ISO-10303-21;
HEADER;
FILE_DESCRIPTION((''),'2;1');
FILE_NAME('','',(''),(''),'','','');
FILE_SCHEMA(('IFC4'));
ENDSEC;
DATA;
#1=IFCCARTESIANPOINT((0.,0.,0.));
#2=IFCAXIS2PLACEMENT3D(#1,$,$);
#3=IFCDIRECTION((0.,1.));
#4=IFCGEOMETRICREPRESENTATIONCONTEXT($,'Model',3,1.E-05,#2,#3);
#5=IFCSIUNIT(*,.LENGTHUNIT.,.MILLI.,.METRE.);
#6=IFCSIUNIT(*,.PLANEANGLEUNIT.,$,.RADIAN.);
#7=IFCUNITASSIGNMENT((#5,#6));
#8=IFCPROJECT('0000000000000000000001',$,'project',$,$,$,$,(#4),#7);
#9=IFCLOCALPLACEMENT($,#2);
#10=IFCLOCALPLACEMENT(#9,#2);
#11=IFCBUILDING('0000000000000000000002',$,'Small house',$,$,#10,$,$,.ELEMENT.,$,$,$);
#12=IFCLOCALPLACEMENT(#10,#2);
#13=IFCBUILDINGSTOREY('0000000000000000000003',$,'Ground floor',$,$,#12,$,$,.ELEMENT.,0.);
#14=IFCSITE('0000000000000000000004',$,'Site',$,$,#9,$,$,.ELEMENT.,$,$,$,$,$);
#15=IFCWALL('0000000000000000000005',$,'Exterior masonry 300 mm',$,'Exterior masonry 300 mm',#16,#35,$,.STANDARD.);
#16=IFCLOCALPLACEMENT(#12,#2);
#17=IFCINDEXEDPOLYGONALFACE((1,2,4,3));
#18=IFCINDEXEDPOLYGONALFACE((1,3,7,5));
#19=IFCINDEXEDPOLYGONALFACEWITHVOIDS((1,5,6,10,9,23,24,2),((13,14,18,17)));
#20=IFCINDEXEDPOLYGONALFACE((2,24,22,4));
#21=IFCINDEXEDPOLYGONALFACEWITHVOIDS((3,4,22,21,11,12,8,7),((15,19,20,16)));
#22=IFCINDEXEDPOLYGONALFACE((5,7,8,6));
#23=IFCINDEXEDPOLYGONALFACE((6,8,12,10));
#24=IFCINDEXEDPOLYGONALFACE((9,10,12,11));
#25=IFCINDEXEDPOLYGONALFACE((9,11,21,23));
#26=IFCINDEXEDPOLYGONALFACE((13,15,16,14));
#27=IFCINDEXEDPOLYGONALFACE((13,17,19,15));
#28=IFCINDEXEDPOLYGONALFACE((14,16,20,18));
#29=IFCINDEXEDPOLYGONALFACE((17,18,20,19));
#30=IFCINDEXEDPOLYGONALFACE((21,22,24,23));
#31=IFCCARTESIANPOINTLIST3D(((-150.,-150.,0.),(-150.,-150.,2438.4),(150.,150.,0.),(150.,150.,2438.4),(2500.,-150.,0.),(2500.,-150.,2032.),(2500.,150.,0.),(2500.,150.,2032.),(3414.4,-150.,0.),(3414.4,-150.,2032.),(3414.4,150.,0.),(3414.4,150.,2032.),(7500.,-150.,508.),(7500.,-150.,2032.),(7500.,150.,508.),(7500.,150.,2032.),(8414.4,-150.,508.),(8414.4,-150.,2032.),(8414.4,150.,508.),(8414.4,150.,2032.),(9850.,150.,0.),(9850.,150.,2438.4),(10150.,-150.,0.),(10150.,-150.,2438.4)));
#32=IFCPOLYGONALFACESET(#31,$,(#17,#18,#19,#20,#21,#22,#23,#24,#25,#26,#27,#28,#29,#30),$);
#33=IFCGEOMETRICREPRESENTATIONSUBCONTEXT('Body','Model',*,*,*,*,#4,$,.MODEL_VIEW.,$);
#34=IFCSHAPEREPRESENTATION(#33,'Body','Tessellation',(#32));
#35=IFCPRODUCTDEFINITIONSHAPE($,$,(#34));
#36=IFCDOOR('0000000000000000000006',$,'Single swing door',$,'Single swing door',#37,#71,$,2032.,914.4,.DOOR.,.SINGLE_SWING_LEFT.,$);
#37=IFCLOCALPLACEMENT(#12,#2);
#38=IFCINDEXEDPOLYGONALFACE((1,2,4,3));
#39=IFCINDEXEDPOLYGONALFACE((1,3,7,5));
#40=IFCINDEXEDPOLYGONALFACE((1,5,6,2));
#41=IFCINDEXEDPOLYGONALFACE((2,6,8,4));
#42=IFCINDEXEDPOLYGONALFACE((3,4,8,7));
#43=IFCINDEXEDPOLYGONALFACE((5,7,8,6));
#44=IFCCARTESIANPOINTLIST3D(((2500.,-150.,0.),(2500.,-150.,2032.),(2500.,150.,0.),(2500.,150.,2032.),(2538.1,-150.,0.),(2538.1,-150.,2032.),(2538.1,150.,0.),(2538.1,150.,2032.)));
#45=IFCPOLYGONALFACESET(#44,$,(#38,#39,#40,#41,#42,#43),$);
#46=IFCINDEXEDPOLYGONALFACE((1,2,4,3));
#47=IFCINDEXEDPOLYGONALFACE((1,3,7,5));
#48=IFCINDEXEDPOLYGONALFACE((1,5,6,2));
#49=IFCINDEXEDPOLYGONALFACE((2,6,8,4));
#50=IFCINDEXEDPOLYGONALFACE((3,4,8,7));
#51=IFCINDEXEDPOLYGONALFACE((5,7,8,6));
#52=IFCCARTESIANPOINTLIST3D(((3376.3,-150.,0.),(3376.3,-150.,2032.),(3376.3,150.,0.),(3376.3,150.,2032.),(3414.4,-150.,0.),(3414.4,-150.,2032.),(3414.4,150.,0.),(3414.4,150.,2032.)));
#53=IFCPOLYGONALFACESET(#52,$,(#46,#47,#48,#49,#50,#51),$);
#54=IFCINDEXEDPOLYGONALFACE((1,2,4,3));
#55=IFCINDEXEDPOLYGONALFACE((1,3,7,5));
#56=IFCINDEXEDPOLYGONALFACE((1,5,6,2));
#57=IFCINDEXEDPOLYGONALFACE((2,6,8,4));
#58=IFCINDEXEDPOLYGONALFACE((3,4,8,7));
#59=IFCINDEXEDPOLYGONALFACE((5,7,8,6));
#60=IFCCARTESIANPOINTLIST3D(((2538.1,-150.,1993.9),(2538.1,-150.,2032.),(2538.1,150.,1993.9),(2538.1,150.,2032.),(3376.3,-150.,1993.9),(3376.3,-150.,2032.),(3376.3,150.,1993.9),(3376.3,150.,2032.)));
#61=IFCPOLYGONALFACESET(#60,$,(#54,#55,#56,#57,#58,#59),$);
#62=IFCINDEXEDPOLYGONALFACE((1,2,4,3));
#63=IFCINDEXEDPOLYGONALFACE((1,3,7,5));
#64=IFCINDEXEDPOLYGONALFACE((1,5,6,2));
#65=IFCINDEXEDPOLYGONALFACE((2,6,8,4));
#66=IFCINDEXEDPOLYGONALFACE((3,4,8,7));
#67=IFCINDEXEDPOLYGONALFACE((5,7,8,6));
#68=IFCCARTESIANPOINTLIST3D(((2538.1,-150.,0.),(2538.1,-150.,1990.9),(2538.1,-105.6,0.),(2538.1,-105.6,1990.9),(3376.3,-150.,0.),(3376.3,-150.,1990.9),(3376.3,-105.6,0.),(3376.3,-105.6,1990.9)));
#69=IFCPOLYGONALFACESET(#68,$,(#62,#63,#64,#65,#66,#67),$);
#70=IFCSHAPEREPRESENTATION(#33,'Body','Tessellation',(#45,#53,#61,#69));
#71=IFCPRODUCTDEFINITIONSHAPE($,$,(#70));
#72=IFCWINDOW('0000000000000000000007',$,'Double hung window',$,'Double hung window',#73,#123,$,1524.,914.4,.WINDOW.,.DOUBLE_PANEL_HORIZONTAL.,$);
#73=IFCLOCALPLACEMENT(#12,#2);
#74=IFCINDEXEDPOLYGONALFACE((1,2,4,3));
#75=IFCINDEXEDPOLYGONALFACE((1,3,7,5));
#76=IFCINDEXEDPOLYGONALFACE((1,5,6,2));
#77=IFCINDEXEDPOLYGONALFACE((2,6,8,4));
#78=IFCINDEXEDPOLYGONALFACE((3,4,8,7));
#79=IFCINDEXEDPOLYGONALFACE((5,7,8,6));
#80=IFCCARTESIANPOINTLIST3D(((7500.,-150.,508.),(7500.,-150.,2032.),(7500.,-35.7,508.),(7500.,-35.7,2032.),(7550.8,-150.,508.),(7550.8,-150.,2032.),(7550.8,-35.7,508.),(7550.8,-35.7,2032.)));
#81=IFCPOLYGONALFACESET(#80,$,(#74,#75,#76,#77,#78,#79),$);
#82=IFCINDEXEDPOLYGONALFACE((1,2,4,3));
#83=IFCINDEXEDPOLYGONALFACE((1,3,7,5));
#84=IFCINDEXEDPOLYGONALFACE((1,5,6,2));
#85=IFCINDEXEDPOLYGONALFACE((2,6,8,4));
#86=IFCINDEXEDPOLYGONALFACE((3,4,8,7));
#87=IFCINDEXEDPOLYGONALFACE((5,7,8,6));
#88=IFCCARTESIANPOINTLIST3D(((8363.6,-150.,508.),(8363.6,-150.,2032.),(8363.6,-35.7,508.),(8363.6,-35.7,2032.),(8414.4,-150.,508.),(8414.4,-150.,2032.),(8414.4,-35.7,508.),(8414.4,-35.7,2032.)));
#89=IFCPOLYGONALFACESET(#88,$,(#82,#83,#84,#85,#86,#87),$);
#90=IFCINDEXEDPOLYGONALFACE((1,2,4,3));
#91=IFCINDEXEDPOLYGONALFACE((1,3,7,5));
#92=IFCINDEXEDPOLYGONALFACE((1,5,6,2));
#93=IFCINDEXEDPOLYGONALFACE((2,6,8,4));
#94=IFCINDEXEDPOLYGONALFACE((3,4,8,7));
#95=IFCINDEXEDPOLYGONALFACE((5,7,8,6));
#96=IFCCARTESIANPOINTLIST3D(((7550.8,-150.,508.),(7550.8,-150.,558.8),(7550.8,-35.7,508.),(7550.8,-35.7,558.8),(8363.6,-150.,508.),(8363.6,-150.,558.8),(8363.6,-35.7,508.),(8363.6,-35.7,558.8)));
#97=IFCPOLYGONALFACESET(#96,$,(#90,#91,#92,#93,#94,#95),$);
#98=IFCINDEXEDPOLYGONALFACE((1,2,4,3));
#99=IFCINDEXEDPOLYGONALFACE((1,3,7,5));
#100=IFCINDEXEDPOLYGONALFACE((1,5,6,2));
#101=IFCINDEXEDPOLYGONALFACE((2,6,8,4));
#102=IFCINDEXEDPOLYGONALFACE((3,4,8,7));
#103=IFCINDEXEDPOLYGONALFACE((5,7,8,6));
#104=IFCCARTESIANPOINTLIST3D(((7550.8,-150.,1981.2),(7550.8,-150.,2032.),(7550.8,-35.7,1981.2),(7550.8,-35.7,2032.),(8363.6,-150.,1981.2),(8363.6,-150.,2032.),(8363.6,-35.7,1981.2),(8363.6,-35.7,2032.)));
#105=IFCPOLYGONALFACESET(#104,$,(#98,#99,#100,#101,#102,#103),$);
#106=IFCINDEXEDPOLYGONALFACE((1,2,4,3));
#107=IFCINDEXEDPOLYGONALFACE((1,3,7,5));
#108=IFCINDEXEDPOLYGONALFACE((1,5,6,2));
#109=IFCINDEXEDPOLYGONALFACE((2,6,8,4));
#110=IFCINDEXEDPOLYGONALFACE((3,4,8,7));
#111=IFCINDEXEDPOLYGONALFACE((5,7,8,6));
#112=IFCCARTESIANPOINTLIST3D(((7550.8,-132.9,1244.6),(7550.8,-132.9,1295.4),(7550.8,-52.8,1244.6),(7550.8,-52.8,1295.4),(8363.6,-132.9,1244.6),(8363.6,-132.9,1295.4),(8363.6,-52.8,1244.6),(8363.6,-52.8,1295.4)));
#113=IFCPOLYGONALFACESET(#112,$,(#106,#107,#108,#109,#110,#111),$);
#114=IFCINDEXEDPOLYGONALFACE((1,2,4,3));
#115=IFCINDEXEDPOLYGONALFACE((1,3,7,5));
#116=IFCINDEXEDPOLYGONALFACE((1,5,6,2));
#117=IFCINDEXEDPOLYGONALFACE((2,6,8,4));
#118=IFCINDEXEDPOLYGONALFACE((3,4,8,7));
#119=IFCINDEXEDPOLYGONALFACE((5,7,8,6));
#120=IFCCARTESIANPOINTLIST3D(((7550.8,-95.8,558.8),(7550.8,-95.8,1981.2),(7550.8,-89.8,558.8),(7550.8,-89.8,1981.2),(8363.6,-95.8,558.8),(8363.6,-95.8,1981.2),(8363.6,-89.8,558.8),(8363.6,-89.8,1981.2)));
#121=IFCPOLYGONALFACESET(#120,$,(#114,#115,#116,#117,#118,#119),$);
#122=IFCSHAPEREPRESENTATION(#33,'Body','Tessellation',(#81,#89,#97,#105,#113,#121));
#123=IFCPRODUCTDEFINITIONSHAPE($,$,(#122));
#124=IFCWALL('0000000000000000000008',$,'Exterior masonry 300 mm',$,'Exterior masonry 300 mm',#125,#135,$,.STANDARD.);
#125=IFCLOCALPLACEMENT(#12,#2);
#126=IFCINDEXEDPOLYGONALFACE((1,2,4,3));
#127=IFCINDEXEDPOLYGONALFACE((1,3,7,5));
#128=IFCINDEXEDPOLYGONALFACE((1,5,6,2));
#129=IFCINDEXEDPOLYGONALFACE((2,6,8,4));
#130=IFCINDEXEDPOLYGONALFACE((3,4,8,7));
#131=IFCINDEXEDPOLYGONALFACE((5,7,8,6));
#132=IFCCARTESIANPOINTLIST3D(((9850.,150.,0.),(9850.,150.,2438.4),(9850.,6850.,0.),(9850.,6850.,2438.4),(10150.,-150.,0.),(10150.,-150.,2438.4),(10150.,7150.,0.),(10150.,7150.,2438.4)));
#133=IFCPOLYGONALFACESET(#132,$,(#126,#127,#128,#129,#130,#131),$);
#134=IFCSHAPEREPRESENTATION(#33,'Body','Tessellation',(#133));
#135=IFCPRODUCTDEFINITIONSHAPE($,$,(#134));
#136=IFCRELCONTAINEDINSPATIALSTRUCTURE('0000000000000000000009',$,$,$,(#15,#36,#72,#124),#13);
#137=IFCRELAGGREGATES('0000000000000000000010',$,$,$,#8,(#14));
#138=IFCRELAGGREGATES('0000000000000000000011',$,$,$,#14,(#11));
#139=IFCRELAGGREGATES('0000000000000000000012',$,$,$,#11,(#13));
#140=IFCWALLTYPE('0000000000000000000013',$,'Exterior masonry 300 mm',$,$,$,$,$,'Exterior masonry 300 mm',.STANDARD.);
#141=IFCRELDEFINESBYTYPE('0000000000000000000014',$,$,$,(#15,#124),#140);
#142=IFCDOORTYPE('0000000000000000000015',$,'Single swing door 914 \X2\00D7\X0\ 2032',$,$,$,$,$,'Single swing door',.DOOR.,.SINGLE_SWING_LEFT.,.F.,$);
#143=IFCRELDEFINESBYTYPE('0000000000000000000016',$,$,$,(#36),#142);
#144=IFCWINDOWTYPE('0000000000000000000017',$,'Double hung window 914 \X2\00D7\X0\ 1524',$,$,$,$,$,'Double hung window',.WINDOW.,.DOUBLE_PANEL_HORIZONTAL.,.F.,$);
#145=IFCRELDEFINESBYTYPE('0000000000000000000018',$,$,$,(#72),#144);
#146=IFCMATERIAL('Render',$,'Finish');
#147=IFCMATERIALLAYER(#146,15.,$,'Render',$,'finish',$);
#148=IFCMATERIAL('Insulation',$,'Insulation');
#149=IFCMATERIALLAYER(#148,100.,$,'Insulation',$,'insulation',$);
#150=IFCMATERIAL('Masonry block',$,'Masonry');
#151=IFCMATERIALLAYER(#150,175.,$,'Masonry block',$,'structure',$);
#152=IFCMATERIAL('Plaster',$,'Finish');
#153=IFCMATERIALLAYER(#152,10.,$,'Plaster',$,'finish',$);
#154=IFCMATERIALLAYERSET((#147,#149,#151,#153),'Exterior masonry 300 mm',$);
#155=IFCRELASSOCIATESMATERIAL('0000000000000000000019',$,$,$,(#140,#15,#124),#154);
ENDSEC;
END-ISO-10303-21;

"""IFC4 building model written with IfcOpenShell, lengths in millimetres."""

from ifc_helpers import new_model, si_unit, direction, frame, origin, origin_with_axes, place, context, subcontext, project, spatial, polyline, outline, extrude, material, layer, layer_set, layer_usage, type_object, element, fill, save


model = new_model("IFC4")

# Units and contexts
model_context = context("Model", 3, precision=1e-05, world=origin(), true_north=direction((0.0, 1.0)))
body_context = subcontext(model_context, "Body", "Model", "MODEL_VIEW")
ifc_project = project(units=[si_unit("LENGTHUNIT", "METRE", prefix="MILLI"), si_unit("PLANEANGLEUNIT", "RADIAN")], contexts=[model_context])

# Site, building, storey
site_placement = place(None, origin())
site = spatial("IfcSite", under=ifc_project, at=site_placement, Name="Site", CompositionType="ELEMENT")
building_placement = place(site_placement, origin())
building = spatial("IfcBuilding", under=site, at=building_placement, Name="Small house", CompositionType="ELEMENT")
storey_placement = place(building_placement, origin())
storey = spatial("IfcBuildingStorey", under=building, at=storey_placement, Name="Ground floor", CompositionType="ELEMENT", Elevation=0.0)

# Wall, openings, door, window
ifc_material_1 = material(Name="Render", Category="Finish")
ifc_layer_1 = layer(ifc_material_1, 15.0, Name="Render", Category="finish")
ifc_material_2 = material(Name="Insulation", Category="Insulation")
ifc_layer_2 = layer(ifc_material_2, 100.0, Name="Insulation", Category="insulation")
ifc_material_3 = material(Name="Masonry block", Category="Masonry")
ifc_layer_3 = layer(ifc_material_3, 175.0, Name="Masonry block", Category="structure")
ifc_material_4 = material(Name="Plaster", Category="Finish")
ifc_layer_4 = layer(ifc_material_4, 10.0, Name="Plaster", Category="finish")
ifc_layer_set_1 = layer_set([ifc_layer_1, ifc_layer_2, ifc_layer_3, ifc_layer_4], Name="Exterior masonry 300 mm")
ifc_layer_usage_1 = layer_usage(ifc_layer_set_1, "AXIS2", "POSITIVE", -150.0)
wall_type_1 = type_object("IfcWallType", Name="Exterior masonry 300 mm", ElementType="Exterior masonry 300 mm", PredefinedType="STANDARD", material=ifc_layer_set_1)
wall_1_placement = place(storey_placement, origin_with_axes())
wall_1 = element("IfcWall", 1, at=wall_1_placement, inside=storey, type_object=wall_type_1, material=ifc_layer_usage_1, Name="Exterior masonry 300 mm", ObjectType="Exterior masonry 300 mm", PredefinedType="STANDARD", context=body_context, shape_type="SweptSolid", body=[
    extrude(outline(polyline([(-150.0, -150.0), (10150.0, -150.0), (9850.0, 150.0), (150.0, 150.0), (-150.0, -150.0)])), origin(), (0.0, 0.0, 1.0), 2438.4),
])
opening_1_placement = place(wall_1_placement, frame((2500.0, 0.0, 0.0), z_axis=(0.0, 0.0, 1.0), x_axis=(1.0, 0.0, 0.0)))
opening_1 = element("IfcOpeningElement", 2, at=opening_1_placement, cuts=wall_1, PredefinedType="OPENING", context=body_context, shape_type="SweptSolid", body=[
    extrude(outline(polyline([(0.0, -160.0), (914.4, -160.0), (914.4, 160.0), (0.0, 160.0), (0.0, -160.0)])), origin(), (0.0, 0.0, 1.0), 2032.0),
])
opening_2_placement = place(wall_1_placement, frame((7500.0, 0.0, 508.0), z_axis=(0.0, 0.0, 1.0), x_axis=(1.0, 0.0, 0.0)))
opening_2 = element("IfcOpeningElement", 3, at=opening_2_placement, cuts=wall_1, PredefinedType="OPENING", context=body_context, shape_type="SweptSolid", body=[
    extrude(outline(polyline([(0.0, -160.0), (914.4, -160.0), (914.4, 160.0), (0.0, 160.0), (0.0, -160.0)])), origin(), (0.0, 0.0, 1.0), 1524.0),
])
door_type = type_object("IfcDoorType", Name="Single swing door 914 × 2032", ElementType="Single swing door", OperationType="SINGLE_SWING_LEFT", ParameterTakesPrecedence=False, PredefinedType="DOOR")
door_1_placement = place(opening_1_placement, origin_with_axes())
door_1 = element("IfcDoor", 4, at=door_1_placement, inside=storey, type_object=door_type, Name="Single swing door", ObjectType="Single swing door", OperationType="SINGLE_SWING_LEFT", OverallHeight=2032.0, OverallWidth=914.4, PredefinedType="DOOR", context=body_context, shape_type="SweptSolid", body=[
    extrude(outline(polyline([(0.0, -150.0), (38.1, -150.0), (38.1, 150.0), (0.0, 150.0), (0.0, -150.0)])), origin(), (0.0, 0.0, 1.0), 2032.0),
    extrude(outline(polyline([(876.3, -150.0), (914.4, -150.0), (914.4, 150.0), (876.3, 150.0), (876.3, -150.0)])), origin(), (0.0, 0.0, 1.0), 2032.0),
    extrude(outline(polyline([(38.1, -150.0), (876.3, -150.0), (876.3, 150.0), (38.1, 150.0), (38.1, -150.0)])), frame((0.0, 0.0, 1993.9)), (0.0, 0.0, 1.0), 38.1),
    extrude(outline(polyline([(38.1, -150.0), (876.3, -150.0), (876.3, -105.5), (38.1, -105.5), (38.1, -150.0)])), origin(), (0.0, 0.0, 1.0), 1990.9),
])
fill(opening_1, door_1)
window_type = type_object("IfcWindowType", Name="Double hung window 914 × 1524", ElementType="Double hung window", ParameterTakesPrecedence=False, PartitioningType="DOUBLE_PANEL_HORIZONTAL", PredefinedType="WINDOW")
window_1_placement = place(opening_2_placement, origin_with_axes())
window_1 = element("IfcWindow", 5, at=window_1_placement, inside=storey, type_object=window_type, Name="Double hung window", ObjectType="Double hung window", OverallHeight=1524.0, OverallWidth=914.4, PartitioningType="DOUBLE_PANEL_HORIZONTAL", PredefinedType="WINDOW", context=body_context, shape_type="SweptSolid", body=[
    extrude(outline(polyline([(0.0, -150.0), (50.8, -150.0), (50.8, -35.7), (0.0, -35.7), (0.0, -150.0)])), origin(), (0.0, 0.0, 1.0), 1524.0),
    extrude(outline(polyline([(863.6, -150.0), (914.4, -150.0), (914.4, -35.7), (863.6, -35.7), (863.6, -150.0)])), origin(), (0.0, 0.0, 1.0), 1524.0),
    extrude(outline(polyline([(50.8, -150.0), (863.6, -150.0), (863.6, -35.7), (50.8, -35.7), (50.8, -150.0)])), origin(), (0.0, 0.0, 1.0), 50.8),
    extrude(outline(polyline([(50.8, -150.0), (863.6, -150.0), (863.6, -35.7), (50.8, -35.7), (50.8, -150.0)])), frame((0.0, 0.0, 1473.2)), (0.0, 0.0, 1.0), 50.8),
    extrude(outline(polyline([(50.8, -132.9), (863.6, -132.9), (863.6, -52.8), (50.8, -52.8), (50.8, -132.9)])), frame((0.0, 0.0, 736.6)), (0.0, 0.0, 1.0), 50.8),
    extrude(outline(polyline([(50.8, -95.8), (863.6, -95.8), (863.6, -89.8), (50.8, -89.8), (50.8, -95.8)])), frame((0.0, 0.0, 50.8)), (0.0, 0.0, 1.0), 1422.4),
])
fill(opening_2, window_1)

# Wall
ifc_layer_usage_2 = layer_usage(ifc_layer_set_1, "AXIS2", "POSITIVE", -150.0)
wall_2_placement = place(storey_placement, frame((10000.0, 0.0, 0.0), z_axis=(0.0, 0.0, 1.0), x_axis=(0.0, 1.0, 0.0)))
element("IfcWall", 6, at=wall_2_placement, inside=storey, type_object=wall_type_1, material=ifc_layer_usage_2, Name="Exterior masonry 300 mm", ObjectType="Exterior masonry 300 mm", PredefinedType="STANDARD", context=body_context, shape_type="SweptSolid", body=[
    extrude(outline(polyline([(-150.0, -150.0), (7150.0, -150.0), (6850.0, 150.0), (150.0, 150.0), (-150.0, -150.0)])), origin(), (0.0, 0.0, 1.0), 2438.4),
])

save(model, "model.ifc")
